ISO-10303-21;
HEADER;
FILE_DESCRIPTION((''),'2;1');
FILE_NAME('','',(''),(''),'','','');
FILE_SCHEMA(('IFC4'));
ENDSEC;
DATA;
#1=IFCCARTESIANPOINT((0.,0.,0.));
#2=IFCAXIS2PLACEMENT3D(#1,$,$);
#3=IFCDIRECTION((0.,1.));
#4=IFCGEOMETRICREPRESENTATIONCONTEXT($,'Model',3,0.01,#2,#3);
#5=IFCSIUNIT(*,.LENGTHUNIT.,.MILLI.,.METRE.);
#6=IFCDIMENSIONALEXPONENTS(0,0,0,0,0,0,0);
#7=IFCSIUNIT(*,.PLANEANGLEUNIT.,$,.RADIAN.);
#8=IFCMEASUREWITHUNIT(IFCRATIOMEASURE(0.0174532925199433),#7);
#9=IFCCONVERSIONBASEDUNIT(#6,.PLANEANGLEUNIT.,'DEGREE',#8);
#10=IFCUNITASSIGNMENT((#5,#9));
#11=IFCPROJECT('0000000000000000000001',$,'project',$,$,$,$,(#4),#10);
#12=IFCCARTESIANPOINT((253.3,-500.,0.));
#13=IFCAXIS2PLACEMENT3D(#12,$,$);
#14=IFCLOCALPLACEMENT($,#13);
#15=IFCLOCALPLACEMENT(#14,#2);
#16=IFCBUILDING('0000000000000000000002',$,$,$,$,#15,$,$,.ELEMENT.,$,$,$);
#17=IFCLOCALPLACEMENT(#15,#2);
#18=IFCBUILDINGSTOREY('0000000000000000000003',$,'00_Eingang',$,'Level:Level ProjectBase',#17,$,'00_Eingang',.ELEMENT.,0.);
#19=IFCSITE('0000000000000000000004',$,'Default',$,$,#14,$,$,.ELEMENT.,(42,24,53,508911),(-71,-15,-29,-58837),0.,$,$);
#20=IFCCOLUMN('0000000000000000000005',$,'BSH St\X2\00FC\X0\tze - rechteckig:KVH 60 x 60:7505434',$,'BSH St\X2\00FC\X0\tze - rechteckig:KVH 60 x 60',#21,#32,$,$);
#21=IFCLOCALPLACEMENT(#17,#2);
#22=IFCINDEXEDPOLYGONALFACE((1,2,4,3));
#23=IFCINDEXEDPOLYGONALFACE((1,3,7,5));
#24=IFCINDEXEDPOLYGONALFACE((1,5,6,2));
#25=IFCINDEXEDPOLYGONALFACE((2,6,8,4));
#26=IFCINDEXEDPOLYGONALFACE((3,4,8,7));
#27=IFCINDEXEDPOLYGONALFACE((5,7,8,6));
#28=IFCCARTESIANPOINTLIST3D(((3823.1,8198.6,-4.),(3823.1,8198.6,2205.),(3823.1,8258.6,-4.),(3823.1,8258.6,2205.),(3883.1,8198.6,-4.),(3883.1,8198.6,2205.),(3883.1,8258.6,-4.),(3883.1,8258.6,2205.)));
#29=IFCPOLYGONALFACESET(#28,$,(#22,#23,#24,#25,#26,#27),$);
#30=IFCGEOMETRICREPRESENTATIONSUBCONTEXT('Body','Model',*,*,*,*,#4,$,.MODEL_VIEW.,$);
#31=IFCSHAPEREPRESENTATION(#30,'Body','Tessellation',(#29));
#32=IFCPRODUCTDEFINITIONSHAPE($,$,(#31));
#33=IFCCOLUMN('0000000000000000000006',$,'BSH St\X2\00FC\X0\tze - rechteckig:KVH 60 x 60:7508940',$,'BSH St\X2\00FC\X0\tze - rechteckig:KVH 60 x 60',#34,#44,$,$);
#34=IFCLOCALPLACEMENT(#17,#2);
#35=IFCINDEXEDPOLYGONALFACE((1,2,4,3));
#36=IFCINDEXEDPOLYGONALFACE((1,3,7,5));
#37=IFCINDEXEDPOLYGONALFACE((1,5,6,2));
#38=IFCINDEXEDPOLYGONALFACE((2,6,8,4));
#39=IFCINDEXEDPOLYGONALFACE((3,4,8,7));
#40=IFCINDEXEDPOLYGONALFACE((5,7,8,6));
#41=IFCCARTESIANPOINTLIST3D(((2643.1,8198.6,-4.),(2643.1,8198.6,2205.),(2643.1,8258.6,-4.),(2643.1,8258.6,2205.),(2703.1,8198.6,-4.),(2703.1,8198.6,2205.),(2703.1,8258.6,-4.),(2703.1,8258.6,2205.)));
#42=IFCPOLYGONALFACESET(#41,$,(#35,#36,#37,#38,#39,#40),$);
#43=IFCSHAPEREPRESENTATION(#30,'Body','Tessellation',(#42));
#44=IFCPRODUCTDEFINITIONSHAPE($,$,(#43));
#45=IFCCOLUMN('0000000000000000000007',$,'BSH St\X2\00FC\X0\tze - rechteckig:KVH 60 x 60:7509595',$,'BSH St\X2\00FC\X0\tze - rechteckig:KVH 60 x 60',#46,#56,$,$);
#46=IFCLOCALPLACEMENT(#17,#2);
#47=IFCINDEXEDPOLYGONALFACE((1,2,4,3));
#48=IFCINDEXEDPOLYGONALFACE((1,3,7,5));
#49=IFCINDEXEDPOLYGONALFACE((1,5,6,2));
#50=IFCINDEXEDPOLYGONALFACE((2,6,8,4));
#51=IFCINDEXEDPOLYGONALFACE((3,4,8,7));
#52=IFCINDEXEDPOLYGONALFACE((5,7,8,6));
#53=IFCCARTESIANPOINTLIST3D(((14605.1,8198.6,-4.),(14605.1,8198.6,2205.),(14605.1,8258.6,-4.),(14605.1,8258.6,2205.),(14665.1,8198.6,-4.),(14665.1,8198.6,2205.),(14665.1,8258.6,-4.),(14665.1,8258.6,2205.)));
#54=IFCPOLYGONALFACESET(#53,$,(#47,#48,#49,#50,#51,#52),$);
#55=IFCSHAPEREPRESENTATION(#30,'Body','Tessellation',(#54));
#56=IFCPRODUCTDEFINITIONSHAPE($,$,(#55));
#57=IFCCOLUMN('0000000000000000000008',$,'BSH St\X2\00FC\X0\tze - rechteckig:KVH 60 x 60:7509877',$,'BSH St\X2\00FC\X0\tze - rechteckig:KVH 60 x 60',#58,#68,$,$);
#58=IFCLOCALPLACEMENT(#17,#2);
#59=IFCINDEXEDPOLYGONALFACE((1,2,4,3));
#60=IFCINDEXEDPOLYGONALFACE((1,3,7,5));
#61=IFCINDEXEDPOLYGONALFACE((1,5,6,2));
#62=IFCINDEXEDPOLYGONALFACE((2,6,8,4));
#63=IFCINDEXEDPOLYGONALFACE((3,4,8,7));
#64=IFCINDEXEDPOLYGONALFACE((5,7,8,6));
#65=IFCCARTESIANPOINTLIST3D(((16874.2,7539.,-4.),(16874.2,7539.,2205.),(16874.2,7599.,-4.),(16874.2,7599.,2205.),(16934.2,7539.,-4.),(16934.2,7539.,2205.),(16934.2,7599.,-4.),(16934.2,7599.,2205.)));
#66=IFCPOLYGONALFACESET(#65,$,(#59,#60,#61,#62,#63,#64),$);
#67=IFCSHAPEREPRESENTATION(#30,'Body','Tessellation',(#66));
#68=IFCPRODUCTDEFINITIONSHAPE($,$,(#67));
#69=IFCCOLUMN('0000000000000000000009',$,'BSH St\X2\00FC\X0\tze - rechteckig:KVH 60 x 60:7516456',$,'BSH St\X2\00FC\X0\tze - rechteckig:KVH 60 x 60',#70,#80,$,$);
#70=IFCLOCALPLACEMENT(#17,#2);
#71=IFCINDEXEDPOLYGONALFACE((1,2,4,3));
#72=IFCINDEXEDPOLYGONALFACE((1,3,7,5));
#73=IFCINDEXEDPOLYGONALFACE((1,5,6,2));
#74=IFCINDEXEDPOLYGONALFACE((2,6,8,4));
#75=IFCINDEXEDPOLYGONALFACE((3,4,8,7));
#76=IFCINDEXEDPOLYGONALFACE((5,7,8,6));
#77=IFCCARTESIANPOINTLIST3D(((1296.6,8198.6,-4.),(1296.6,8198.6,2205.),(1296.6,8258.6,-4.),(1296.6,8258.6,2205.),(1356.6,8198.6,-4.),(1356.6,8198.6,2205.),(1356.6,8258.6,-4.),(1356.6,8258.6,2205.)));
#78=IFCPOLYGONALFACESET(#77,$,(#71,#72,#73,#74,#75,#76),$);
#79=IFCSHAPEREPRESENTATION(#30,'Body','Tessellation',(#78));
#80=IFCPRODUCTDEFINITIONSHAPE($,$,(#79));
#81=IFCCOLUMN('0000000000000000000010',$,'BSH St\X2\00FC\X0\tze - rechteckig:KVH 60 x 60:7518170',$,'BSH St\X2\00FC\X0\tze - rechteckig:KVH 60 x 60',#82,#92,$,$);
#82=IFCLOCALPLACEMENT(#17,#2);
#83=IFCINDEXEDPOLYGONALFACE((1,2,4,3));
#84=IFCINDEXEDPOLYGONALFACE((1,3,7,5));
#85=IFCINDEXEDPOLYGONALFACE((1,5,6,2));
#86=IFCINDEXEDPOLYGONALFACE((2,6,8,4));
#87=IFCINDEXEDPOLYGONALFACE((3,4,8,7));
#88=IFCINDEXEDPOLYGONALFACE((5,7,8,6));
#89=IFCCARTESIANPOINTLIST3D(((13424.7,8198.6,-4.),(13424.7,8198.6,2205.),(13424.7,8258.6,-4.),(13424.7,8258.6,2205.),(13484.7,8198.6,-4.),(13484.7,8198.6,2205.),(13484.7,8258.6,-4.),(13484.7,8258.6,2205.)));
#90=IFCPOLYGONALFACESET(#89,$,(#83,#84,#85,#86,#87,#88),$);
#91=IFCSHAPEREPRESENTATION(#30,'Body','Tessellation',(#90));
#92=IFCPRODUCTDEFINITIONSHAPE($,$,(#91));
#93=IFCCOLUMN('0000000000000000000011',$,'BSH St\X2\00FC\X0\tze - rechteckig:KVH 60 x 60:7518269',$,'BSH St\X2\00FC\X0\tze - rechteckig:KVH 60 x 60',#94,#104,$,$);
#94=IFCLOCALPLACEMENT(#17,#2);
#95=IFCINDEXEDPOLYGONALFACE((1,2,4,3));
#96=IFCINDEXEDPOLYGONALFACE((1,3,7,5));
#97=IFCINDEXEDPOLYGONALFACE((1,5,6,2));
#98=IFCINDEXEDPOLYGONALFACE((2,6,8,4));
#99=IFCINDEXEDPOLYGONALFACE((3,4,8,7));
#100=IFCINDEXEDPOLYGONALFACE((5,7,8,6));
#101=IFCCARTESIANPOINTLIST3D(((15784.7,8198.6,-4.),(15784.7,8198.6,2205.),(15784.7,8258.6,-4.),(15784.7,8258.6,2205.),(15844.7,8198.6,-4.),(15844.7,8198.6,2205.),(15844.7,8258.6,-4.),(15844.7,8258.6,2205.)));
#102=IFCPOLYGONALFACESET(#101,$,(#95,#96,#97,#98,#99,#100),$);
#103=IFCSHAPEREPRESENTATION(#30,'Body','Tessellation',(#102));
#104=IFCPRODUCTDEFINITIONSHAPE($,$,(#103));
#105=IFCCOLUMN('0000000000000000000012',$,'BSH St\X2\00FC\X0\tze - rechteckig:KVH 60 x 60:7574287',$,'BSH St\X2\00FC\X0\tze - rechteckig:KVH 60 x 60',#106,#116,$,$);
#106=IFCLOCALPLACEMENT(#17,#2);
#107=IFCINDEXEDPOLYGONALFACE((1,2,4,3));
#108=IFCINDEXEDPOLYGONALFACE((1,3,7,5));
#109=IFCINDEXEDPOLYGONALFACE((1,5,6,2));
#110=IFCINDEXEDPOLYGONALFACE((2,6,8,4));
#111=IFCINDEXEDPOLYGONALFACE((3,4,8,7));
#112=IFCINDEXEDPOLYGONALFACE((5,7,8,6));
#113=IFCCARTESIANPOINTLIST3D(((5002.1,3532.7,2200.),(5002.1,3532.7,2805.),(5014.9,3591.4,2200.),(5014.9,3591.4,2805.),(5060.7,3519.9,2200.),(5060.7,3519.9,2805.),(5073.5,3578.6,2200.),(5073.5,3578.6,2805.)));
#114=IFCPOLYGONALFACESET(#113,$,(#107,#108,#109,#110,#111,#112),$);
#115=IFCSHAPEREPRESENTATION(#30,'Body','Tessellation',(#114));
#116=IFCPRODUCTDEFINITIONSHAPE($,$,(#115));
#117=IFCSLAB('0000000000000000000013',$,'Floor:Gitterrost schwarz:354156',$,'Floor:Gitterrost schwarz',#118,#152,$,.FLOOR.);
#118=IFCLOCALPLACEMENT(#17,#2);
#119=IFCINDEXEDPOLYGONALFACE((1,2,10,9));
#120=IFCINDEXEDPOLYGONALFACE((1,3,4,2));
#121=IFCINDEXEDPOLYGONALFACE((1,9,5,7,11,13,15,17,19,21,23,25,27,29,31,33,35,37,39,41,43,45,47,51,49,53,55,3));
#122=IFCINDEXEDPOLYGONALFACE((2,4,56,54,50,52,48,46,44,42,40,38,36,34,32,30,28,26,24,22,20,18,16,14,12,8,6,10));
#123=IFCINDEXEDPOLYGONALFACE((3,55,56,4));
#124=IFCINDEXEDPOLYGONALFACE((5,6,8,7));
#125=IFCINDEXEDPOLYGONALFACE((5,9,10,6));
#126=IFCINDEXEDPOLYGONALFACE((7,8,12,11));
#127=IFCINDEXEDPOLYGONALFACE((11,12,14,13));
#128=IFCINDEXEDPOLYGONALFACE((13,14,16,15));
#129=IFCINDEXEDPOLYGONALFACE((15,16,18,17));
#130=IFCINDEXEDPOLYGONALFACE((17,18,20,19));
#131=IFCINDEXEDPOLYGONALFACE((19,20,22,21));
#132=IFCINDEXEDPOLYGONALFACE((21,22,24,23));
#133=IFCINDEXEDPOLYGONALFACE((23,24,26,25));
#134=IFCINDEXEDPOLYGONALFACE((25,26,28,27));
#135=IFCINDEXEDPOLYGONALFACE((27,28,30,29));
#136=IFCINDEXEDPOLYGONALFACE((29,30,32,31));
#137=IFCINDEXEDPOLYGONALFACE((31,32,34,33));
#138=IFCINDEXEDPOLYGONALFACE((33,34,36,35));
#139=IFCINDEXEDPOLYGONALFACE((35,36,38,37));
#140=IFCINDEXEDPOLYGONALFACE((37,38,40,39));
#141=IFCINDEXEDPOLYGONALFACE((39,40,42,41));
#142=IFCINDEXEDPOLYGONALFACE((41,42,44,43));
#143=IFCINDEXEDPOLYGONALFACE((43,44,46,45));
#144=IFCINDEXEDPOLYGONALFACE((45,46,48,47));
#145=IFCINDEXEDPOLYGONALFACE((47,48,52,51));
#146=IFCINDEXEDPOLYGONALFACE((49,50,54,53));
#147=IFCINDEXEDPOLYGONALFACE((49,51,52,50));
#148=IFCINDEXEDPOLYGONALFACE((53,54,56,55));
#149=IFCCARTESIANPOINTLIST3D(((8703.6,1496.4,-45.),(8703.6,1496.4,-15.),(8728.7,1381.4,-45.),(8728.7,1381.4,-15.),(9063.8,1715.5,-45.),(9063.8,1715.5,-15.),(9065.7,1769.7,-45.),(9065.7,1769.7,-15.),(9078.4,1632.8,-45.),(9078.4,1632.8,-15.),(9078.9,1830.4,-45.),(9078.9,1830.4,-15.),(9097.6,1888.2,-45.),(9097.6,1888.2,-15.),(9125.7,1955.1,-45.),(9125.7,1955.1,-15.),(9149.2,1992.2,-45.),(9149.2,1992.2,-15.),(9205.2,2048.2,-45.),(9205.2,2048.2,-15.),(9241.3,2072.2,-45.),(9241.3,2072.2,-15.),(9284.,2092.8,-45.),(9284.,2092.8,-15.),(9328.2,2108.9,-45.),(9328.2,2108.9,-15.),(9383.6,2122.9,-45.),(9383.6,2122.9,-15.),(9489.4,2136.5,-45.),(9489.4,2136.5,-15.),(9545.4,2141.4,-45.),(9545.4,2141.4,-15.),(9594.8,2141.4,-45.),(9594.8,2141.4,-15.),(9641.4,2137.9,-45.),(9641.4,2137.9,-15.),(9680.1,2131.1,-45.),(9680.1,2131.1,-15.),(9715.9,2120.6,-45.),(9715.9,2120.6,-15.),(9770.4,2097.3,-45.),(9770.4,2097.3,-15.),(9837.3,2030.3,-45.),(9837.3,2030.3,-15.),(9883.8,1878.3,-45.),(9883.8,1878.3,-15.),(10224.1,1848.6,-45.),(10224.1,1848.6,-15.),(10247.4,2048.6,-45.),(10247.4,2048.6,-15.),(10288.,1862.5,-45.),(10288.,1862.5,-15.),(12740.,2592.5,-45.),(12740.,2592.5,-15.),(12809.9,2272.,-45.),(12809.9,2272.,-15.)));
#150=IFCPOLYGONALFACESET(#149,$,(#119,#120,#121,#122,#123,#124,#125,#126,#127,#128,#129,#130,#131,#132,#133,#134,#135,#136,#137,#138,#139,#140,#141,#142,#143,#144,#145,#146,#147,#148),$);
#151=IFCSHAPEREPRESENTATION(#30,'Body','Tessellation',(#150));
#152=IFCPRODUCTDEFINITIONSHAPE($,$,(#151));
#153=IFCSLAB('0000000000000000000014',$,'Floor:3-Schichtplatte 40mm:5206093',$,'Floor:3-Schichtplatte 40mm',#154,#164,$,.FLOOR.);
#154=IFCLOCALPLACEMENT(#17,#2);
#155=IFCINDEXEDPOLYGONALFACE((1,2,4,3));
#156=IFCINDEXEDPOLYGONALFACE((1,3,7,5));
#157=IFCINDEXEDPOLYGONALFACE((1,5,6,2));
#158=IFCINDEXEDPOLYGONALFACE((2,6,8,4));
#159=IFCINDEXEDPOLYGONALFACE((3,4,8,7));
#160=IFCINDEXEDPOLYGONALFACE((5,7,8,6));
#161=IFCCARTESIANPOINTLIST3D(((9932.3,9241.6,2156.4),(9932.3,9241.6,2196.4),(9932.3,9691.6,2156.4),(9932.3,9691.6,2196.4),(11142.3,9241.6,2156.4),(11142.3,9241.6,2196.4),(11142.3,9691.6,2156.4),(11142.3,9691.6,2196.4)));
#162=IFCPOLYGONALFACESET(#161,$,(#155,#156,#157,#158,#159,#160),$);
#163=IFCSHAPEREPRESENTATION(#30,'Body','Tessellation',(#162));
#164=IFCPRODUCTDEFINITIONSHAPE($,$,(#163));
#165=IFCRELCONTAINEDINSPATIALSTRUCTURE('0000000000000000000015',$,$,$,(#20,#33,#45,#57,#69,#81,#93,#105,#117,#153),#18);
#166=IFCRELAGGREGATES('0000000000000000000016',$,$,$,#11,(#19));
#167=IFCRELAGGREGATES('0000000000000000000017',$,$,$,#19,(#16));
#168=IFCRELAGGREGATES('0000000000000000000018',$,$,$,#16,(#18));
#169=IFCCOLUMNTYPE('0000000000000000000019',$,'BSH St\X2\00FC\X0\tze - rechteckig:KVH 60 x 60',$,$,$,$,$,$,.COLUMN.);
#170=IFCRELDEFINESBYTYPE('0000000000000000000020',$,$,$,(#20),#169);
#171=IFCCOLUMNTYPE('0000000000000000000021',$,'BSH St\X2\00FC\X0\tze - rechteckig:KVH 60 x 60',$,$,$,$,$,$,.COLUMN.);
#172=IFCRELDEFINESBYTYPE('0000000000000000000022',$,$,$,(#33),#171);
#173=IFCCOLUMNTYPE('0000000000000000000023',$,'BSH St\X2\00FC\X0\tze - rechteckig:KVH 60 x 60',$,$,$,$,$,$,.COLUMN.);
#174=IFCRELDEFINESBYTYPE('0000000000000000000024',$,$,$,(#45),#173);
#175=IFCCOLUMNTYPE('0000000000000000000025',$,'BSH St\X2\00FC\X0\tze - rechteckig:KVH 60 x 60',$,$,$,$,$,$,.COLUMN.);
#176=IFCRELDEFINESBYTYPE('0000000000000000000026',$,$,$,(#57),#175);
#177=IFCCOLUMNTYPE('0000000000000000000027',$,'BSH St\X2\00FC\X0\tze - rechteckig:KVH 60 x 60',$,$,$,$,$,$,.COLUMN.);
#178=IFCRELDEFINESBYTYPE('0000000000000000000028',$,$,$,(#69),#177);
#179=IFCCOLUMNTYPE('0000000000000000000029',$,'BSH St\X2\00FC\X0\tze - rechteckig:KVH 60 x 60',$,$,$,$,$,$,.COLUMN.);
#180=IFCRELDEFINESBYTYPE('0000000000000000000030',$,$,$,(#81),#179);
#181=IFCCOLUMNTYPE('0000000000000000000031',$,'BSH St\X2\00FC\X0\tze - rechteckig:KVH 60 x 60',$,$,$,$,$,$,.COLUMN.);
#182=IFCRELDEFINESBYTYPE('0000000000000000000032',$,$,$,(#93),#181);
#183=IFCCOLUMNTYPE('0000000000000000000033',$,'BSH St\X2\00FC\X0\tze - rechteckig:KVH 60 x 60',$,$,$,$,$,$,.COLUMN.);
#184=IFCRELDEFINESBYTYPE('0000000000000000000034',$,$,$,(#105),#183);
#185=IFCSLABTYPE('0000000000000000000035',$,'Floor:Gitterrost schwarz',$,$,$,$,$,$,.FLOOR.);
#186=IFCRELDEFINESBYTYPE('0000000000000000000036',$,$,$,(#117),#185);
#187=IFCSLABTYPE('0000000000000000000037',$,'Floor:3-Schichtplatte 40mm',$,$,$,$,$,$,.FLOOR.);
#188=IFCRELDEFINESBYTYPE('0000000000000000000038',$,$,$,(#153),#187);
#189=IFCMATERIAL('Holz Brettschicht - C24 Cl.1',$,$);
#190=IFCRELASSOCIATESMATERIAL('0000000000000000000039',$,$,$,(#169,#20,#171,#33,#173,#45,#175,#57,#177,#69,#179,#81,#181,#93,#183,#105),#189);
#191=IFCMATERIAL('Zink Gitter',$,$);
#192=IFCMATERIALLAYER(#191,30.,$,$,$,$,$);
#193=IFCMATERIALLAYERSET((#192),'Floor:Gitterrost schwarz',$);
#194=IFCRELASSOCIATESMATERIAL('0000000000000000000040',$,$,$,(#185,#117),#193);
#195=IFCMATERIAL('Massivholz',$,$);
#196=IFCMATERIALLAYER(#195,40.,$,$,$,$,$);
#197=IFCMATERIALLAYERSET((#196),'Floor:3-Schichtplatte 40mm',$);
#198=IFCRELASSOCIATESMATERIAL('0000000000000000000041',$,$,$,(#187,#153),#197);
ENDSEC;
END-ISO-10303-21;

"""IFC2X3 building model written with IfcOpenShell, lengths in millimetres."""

from ifc_helpers import new_model, entity, si_unit, converted_unit, direction, frame, frame_2d, origin, origin_2d_with_axis, place, context, subcontext, project, spatial, polyline, rectangle, outline, extrude, source, transform, mapped, material, layer, layer_set, layer_usage, type_object, type_shapes, element, save


model = new_model("IFC2X3")

# Units and contexts
model_context = context("Model", 3, precision=0.01, world=origin(), true_north=direction((0.0, 1.0)))
body_context = subcontext(model_context, "Body", "Model", "MODEL_VIEW")
ifc_project = project(units=[si_unit("LENGTHUNIT", "METRE", prefix="MILLI"), converted_unit("PLANEANGLEUNIT", "DEGREE", entity("IfcRatioMeasure", 0.0174532925199433), si_unit("PLANEANGLEUNIT", "RADIAN"), dimensions=[0, 0, 0, 0, 0, 0, 0])], contexts=[model_context])

# Site, building, storey
site_placement = place(None, frame((253.3, -500.0, 0.0)))
site = spatial("IfcSite", under=ifc_project, at=site_placement, Name="Default", CompositionType="ELEMENT", RefLatitude=(42, 24, 53, 508911), RefLongitude=(-71, -15, -29, -58837), RefElevation=0.0)
building_placement = place(site_placement, origin())
building = spatial("IfcBuilding", under=site, at=building_placement, CompositionType="ELEMENT")
storey_placement = place(building_placement, origin())
storey = spatial("IfcBuildingStorey", under=building, at=storey_placement, Name="00_Eingang", ObjectType="Level:Level ProjectBase", LongName="00_Eingang", CompositionType="ELEMENT", Elevation=0.0)

# Columns
ifc_material_1 = material(Name="Holz Brettschicht - C24 Cl.1")
column_type_1 = type_object("IfcColumnType", Name="BSH Stütze - rechteckig:KVH 60 x 60", PredefinedType="COLUMN", material=ifc_material_1)
shared_shape_1 = source(origin(), body_context, "Body", "SweptSolid", [
    extrude(rectangle(XDim=60.0, YDim=60.0, at=frame_2d((0.0, 0.0), x_axis=(1.0, 0.0))), frame((3853.1, 8228.6, -4.0), z_axis=(0.0, 0.0, 1.0), x_axis=(0.0, -1.0, 0.0)), (0.0, 0.0, 1.0), 2209.0),
])
type_shapes(column_type_1, [shared_shape_1])
column_1_placement = place(storey_placement, origin())
element("IfcColumn", 1, at=column_1_placement, inside=storey, type_object=column_type_1, material=ifc_material_1, Name="BSH Stütze - rechteckig:KVH 60 x 60:7505434", ObjectType="BSH Stütze - rechteckig:KVH 60 x 60", context=body_context, shape_type="MappedRepresentation", body=[
    mapped(shared_shape_1, transform((0.0, 0.0, 0.0), scale=1.0)),
])
column_type_2 = type_object("IfcColumnType", Name="BSH Stütze - rechteckig:KVH 60 x 60", PredefinedType="COLUMN", material=ifc_material_1)
shared_shape_2 = source(origin(), body_context, "Body", "SweptSolid", [
    extrude(rectangle(XDim=60.0, YDim=60.0, at=frame_2d((0.0, 0.0), x_axis=(1.0, 0.0))), frame((2673.1, 8228.6, -4.0), z_axis=(0.0, 0.0, 1.0), x_axis=(0.0, -1.0, 0.0)), (0.0, 0.0, 1.0), 2209.0),
])
type_shapes(column_type_2, [shared_shape_2])
column_2_placement = place(storey_placement, origin())
element("IfcColumn", 2, at=column_2_placement, inside=storey, type_object=column_type_2, material=ifc_material_1, Name="BSH Stütze - rechteckig:KVH 60 x 60:7508940", ObjectType="BSH Stütze - rechteckig:KVH 60 x 60", context=body_context, shape_type="MappedRepresentation", body=[
    mapped(shared_shape_2, transform((0.0, 0.0, 0.0), scale=1.0)),
])
column_type_3 = type_object("IfcColumnType", Name="BSH Stütze - rechteckig:KVH 60 x 60", PredefinedType="COLUMN", material=ifc_material_1)
shared_shape_3 = source(origin(), body_context, "Body", "SweptSolid", [
    extrude(rectangle(XDim=60.0, YDim=60.0, at=origin_2d_with_axis()), frame((14635.1, 8228.6, -4.0), z_axis=(0.0, 0.0, 1.0), x_axis=(0.0, -1.0, 0.0)), (0.0, 0.0, 1.0), 2209.0),
])
type_shapes(column_type_3, [shared_shape_3])
column_3_placement = place(storey_placement, origin())
element("IfcColumn", 3, at=column_3_placement, inside=storey, type_object=column_type_3, material=ifc_material_1, Name="BSH Stütze - rechteckig:KVH 60 x 60:7509595", ObjectType="BSH Stütze - rechteckig:KVH 60 x 60", context=body_context, shape_type="MappedRepresentation", body=[
    mapped(shared_shape_3, transform((0.0, 0.0, 0.0), scale=1.0)),
])
column_type_4 = type_object("IfcColumnType", Name="BSH Stütze - rechteckig:KVH 60 x 60", PredefinedType="COLUMN", material=ifc_material_1)
shared_shape_4 = source(origin(), body_context, "Body", "SweptSolid", [
    extrude(rectangle(XDim=60.0, YDim=60.0, at=origin_2d_with_axis()), frame((16904.2, 7569.0, -4.0), z_axis=(0.0, 0.0, 1.0), x_axis=(0.0, -1.0, 0.0)), (0.0, 0.0, 1.0), 2209.0),
])
type_shapes(column_type_4, [shared_shape_4])
column_4_placement = place(storey_placement, origin())
element("IfcColumn", 4, at=column_4_placement, inside=storey, type_object=column_type_4, material=ifc_material_1, Name="BSH Stütze - rechteckig:KVH 60 x 60:7509877", ObjectType="BSH Stütze - rechteckig:KVH 60 x 60", context=body_context, shape_type="MappedRepresentation", body=[
    mapped(shared_shape_4, transform((0.0, 0.0, 0.0), scale=1.0)),
])
column_type_5 = type_object("IfcColumnType", Name="BSH Stütze - rechteckig:KVH 60 x 60", PredefinedType="COLUMN", material=ifc_material_1)
shared_shape_5 = source(origin(), body_context, "Body", "SweptSolid", [
    extrude(rectangle(XDim=60.0, YDim=60.0, at=frame_2d((0.0, 0.0), x_axis=(1.0, 0.0))), frame((1326.6, 8228.6, -4.0), z_axis=(0.0, 0.0, 1.0), x_axis=(0.0, -1.0, 0.0)), (0.0, 0.0, 1.0), 2209.0),
])
type_shapes(column_type_5, [shared_shape_5])
column_5_placement = place(storey_placement, origin())
element("IfcColumn", 5, at=column_5_placement, inside=storey, type_object=column_type_5, material=ifc_material_1, Name="BSH Stütze - rechteckig:KVH 60 x 60:7516456", ObjectType="BSH Stütze - rechteckig:KVH 60 x 60", context=body_context, shape_type="MappedRepresentation", body=[
    mapped(shared_shape_5, transform((0.0, 0.0, 0.0), scale=1.0)),
])
column_type_6 = type_object("IfcColumnType", Name="BSH Stütze - rechteckig:KVH 60 x 60", PredefinedType="COLUMN", material=ifc_material_1)
shared_shape_6 = source(origin(), body_context, "Body", "SweptSolid", [
    extrude(rectangle(XDim=60.0, YDim=60.0, at=origin_2d_with_axis()), frame((13454.7, 8228.6, -4.0), z_axis=(0.0, 0.0, 1.0), x_axis=(0.0, -1.0, 0.0)), (0.0, 0.0, 1.0), 2209.0),
])
type_shapes(column_type_6, [shared_shape_6])
column_6_placement = place(storey_placement, origin())
element("IfcColumn", 6, at=column_6_placement, inside=storey, type_object=column_type_6, material=ifc_material_1, Name="BSH Stütze - rechteckig:KVH 60 x 60:7518170", ObjectType="BSH Stütze - rechteckig:KVH 60 x 60", context=body_context, shape_type="MappedRepresentation", body=[
    mapped(shared_shape_6, transform((0.0, 0.0, 0.0), scale=1.0)),
])
column_type_7 = type_object("IfcColumnType", Name="BSH Stütze - rechteckig:KVH 60 x 60", PredefinedType="COLUMN", material=ifc_material_1)
shared_shape_7 = source(origin(), body_context, "Body", "SweptSolid", [
    extrude(rectangle(XDim=60.0, YDim=60.0, at=origin_2d_with_axis()), frame((15814.7, 8228.6, -4.0), z_axis=(0.0, 0.0, 1.0), x_axis=(0.0, -1.0, 0.0)), (0.0, 0.0, 1.0), 2209.0),
])
type_shapes(column_type_7, [shared_shape_7])
column_7_placement = place(storey_placement, origin())
element("IfcColumn", 7, at=column_7_placement, inside=storey, type_object=column_type_7, material=ifc_material_1, Name="BSH Stütze - rechteckig:KVH 60 x 60:7518269", ObjectType="BSH Stütze - rechteckig:KVH 60 x 60", context=body_context, shape_type="MappedRepresentation", body=[
    mapped(shared_shape_7, transform((0.0, 0.0, 0.0), scale=1.0)),
])
column_type_8 = type_object("IfcColumnType", Name="BSH Stütze - rechteckig:KVH 60 x 60", PredefinedType="COLUMN", material=ifc_material_1)
shared_shape_8 = source(origin(), body_context, "Body", "SweptSolid", [
    extrude(rectangle(XDim=60.0, YDim=60.0, at=frame_2d((0.0, 0.0), x_axis=(1.0, 0.0))), frame((5037.8, 3555.6, 2200.0), z_axis=(0.0, 0.0, 1.0), x_axis=(0.213201, 0.977008, 0.0)), (0.0, 0.0, 1.0), 605.0),
])
type_shapes(column_type_8, [shared_shape_8])
column_8_placement = place(storey_placement, origin())
element("IfcColumn", 8, at=column_8_placement, inside=storey, type_object=column_type_8, material=ifc_material_1, Name="BSH Stütze - rechteckig:KVH 60 x 60:7574287", ObjectType="BSH Stütze - rechteckig:KVH 60 x 60", context=body_context, shape_type="MappedRepresentation", body=[
    mapped(shared_shape_8, transform((0.0, 0.0, 0.0), scale=1.0)),
])

# Slabs
ifc_material_2 = material(Name="Zink Gitter")
ifc_layer_1 = layer(ifc_material_2, 30.0)
ifc_layer_set_1 = layer_set([ifc_layer_1], Name="Floor:Gitterrost schwarz")
ifc_layer_usage_1 = layer_usage(ifc_layer_set_1, "AXIS3", "POSITIVE", 0.0)
slab_type_1 = type_object("IfcSlabType", Name="Floor:Gitterrost schwarz", PredefinedType="FLOOR", material=ifc_layer_set_1)
slab_1_placement = place(storey_placement, origin())
element("IfcSlab", 9, at=slab_1_placement, inside=storey, type_object=slab_type_1, material=ifc_layer_usage_1, Name="Floor:Gitterrost schwarz:354156", ObjectType="Floor:Gitterrost schwarz", PredefinedType="FLOOR", context=body_context, shape_type="SweptSolid", body=[
    extrude(outline(polyline([(569.5, 58.0), (3120.8, 58.0), (3120.8, 386.0), (-1056.5, 386.0), (-1056.5, 268.3), (-661.3, 214.9), (-657.9, 131.1), (-644.5, 78.4), (-618.6, 22.0), (-588.0, -30.5), (-546.3, -89.9), (-515.5, -121.1), (-448.8, -163.9), (-408.4, -179.6), (-362.4, -190.7), (-315.7, -197.0), (-258.6, -198.9), (-152.4, -189.5), (-96.5, -182.4), (-48.3, -171.8), (-3.5, -158.5), (32.8, -143.6), (65.6, -125.8), (113.8, -91.3), (164.9, -11.7), (177.9, 146.7), (504.1, 248.4), (569.5, 248.4), (569.5, 58.0)])), frame((9678.6, 1983.8, -15.0), z_axis=(0.0, 0.0, -1.0), x_axis=(0.977008, 0.213201, 0.0)), (0.0, 0.0, 1.0), 30.0),
])
ifc_material_3 = material(Name="Massivholz")
ifc_layer_2 = layer(ifc_material_3, 40.0)
ifc_layer_set_2 = layer_set([ifc_layer_2], Name="Floor:3-Schichtplatte 40mm")
ifc_layer_usage_2 = layer_usage(ifc_layer_set_2, "AXIS3", "POSITIVE", 0.0)
slab_type_2 = type_object("IfcSlabType", Name="Floor:3-Schichtplatte 40mm", PredefinedType="FLOOR", material=ifc_layer_set_2)
slab_2_placement = place(storey_placement, origin())
element("IfcSlab", 10, at=slab_2_placement, inside=storey, type_object=slab_type_2, material=ifc_layer_usage_2, Name="Floor:3-Schichtplatte 40mm:5206093", ObjectType="Floor:3-Schichtplatte 40mm", PredefinedType="FLOOR", context=body_context, shape_type="SweptSolid", body=[
    extrude(rectangle(XDim=450.0, YDim=1210.0, at=origin_2d_with_axis()), frame((10537.3, 9466.6, 2196.4), z_axis=(0.0, 0.0, -1.0), x_axis=(0.0, 1.0, 0.0)), (0.0, 0.0, 1.0), 40.0),
])

save(model, "model.ifc")
